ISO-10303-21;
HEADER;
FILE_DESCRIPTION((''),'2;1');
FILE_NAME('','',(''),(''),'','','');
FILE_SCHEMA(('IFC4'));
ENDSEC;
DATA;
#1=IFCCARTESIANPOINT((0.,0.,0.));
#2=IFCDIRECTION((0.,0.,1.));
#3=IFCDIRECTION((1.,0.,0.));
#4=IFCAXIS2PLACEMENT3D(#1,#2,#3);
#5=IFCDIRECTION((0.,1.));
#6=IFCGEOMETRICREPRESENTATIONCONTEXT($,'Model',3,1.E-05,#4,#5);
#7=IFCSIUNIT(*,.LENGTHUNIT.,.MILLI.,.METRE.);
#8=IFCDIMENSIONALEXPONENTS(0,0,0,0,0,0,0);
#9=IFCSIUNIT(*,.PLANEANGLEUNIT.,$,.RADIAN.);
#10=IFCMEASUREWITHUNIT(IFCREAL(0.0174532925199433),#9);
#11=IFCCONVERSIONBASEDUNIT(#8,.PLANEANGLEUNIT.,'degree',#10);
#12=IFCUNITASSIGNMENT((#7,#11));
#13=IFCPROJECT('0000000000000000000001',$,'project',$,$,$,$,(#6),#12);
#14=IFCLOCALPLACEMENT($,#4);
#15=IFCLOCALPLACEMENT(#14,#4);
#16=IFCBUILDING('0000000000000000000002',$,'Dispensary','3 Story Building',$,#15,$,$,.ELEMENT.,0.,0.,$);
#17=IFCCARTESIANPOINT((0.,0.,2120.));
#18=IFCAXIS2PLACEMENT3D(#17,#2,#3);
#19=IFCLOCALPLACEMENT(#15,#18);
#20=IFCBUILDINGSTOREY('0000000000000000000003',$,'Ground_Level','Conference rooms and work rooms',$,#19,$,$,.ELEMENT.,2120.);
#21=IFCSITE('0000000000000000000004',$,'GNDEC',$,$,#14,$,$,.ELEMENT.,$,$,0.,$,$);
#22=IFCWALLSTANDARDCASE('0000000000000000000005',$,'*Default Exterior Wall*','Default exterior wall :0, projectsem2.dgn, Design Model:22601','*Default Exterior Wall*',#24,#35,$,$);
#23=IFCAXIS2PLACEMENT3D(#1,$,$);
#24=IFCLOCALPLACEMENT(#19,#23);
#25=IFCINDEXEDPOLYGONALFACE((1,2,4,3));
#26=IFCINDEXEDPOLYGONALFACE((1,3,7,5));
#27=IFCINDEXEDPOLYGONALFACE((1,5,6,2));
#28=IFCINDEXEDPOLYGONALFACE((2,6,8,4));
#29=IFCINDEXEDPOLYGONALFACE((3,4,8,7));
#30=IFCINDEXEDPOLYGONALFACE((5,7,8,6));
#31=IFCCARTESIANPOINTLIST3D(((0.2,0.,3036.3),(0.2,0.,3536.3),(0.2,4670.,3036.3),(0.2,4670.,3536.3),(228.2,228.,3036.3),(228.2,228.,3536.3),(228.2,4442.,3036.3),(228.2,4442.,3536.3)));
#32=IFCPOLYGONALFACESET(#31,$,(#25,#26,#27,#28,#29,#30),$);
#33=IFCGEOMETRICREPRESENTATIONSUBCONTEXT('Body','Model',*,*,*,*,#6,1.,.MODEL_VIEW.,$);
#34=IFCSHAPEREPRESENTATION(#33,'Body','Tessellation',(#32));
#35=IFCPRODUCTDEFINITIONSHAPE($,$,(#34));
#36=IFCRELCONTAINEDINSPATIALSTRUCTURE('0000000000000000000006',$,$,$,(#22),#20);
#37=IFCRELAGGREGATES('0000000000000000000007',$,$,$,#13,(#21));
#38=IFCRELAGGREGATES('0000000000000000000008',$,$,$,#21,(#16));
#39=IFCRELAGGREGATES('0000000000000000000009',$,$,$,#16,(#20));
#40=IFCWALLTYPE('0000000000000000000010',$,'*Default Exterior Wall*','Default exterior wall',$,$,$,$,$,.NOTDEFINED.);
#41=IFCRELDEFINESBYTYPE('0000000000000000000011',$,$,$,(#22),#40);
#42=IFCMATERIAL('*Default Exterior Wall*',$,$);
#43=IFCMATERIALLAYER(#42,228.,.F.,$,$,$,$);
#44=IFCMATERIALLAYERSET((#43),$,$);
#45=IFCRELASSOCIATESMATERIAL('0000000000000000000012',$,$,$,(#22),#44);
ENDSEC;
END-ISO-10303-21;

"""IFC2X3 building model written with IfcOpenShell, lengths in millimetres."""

from ifc_helpers import new_model, entity, si_unit, converted_unit, direction, frame, origin_with_axes, place, context, subcontext, project, spatial, polyline, outline, extrude, material, layer, layer_set, layer_usage, type_object, element, save


model = new_model("IFC2X3")

# Units and contexts
model_context = context("Model", 3, precision=1e-05, world=origin_with_axes(), true_north=direction((0.0, 1.0)))
body_context = subcontext(model_context, "Body", "Model", "MODEL_VIEW", scale=1.0)
ifc_project = project(units=[si_unit("LENGTHUNIT", "METRE", prefix="MILLI"), converted_unit("PLANEANGLEUNIT", "degree", entity("IfcReal", 0.0174532925199433), si_unit("PLANEANGLEUNIT", "RADIAN"), dimensions=[0, 0, 0, 0, 0, 0, 0])], contexts=[model_context])

# Site, building, storey
site_placement = place(None, origin_with_axes())
site = spatial("IfcSite", under=ifc_project, at=site_placement, Name="GNDEC", CompositionType="ELEMENT", RefElevation=0.0)
building_placement = place(site_placement, origin_with_axes())
building = spatial("IfcBuilding", under=site, at=building_placement, Name="Dispensary", Description="3 Story Building", CompositionType="ELEMENT", ElevationOfRefHeight=0.0, ElevationOfTerrain=0.0)
storey_placement = place(building_placement, frame((0.0, 0.0, 2120.0), z_axis=(0.0, 0.0, 1.0), x_axis=(1.0, 0.0, 0.0)))
storey = spatial("IfcBuildingStorey", under=building, at=storey_placement, Name="Ground_Level", Description="Conference rooms and work rooms", CompositionType="ELEMENT", Elevation=2120.0)

# Wall
ifc_material_1 = material(Name="*Default Exterior Wall*")
ifc_layer_1 = layer(ifc_material_1, 228.0, ventilated=False)
ifc_layer_set_1 = layer_set([ifc_layer_1])
ifc_layer_usage_1 = layer_usage(ifc_layer_set_1, "AXIS2", "POSITIVE", 0.0)
wall_type_1 = type_object("IfcWallType", Name="*Default Exterior Wall*", Description="Default exterior wall", PredefinedType="NOTDEFINED")
wall_1_placement = place(storey_placement, frame((0.2, 0.0, 3036.3), z_axis=(0.0, 0.0, 1.0), x_axis=(0.0, 1.0, 0.0)))
element("IfcWallStandardCase", 1, at=wall_1_placement, inside=storey, type_object=wall_type_1, material=ifc_layer_usage_1, Name="*Default Exterior Wall*", Description="Default exterior wall :0, projectsem2.dgn, Design Model:22601", ObjectType="*Default Exterior Wall*", context=body_context, shape_type="SweptSolid", body=[
    extrude(outline(polyline([(4670.0, 0.0), (0.0, 0.0), (228.0, -228.0), (4442.0, -228.0), (4670.0, 0.0)])), origin_with_axes(), (0.0, 0.0, 1.0), 500.0),
])

save(model, "model.ifc")
